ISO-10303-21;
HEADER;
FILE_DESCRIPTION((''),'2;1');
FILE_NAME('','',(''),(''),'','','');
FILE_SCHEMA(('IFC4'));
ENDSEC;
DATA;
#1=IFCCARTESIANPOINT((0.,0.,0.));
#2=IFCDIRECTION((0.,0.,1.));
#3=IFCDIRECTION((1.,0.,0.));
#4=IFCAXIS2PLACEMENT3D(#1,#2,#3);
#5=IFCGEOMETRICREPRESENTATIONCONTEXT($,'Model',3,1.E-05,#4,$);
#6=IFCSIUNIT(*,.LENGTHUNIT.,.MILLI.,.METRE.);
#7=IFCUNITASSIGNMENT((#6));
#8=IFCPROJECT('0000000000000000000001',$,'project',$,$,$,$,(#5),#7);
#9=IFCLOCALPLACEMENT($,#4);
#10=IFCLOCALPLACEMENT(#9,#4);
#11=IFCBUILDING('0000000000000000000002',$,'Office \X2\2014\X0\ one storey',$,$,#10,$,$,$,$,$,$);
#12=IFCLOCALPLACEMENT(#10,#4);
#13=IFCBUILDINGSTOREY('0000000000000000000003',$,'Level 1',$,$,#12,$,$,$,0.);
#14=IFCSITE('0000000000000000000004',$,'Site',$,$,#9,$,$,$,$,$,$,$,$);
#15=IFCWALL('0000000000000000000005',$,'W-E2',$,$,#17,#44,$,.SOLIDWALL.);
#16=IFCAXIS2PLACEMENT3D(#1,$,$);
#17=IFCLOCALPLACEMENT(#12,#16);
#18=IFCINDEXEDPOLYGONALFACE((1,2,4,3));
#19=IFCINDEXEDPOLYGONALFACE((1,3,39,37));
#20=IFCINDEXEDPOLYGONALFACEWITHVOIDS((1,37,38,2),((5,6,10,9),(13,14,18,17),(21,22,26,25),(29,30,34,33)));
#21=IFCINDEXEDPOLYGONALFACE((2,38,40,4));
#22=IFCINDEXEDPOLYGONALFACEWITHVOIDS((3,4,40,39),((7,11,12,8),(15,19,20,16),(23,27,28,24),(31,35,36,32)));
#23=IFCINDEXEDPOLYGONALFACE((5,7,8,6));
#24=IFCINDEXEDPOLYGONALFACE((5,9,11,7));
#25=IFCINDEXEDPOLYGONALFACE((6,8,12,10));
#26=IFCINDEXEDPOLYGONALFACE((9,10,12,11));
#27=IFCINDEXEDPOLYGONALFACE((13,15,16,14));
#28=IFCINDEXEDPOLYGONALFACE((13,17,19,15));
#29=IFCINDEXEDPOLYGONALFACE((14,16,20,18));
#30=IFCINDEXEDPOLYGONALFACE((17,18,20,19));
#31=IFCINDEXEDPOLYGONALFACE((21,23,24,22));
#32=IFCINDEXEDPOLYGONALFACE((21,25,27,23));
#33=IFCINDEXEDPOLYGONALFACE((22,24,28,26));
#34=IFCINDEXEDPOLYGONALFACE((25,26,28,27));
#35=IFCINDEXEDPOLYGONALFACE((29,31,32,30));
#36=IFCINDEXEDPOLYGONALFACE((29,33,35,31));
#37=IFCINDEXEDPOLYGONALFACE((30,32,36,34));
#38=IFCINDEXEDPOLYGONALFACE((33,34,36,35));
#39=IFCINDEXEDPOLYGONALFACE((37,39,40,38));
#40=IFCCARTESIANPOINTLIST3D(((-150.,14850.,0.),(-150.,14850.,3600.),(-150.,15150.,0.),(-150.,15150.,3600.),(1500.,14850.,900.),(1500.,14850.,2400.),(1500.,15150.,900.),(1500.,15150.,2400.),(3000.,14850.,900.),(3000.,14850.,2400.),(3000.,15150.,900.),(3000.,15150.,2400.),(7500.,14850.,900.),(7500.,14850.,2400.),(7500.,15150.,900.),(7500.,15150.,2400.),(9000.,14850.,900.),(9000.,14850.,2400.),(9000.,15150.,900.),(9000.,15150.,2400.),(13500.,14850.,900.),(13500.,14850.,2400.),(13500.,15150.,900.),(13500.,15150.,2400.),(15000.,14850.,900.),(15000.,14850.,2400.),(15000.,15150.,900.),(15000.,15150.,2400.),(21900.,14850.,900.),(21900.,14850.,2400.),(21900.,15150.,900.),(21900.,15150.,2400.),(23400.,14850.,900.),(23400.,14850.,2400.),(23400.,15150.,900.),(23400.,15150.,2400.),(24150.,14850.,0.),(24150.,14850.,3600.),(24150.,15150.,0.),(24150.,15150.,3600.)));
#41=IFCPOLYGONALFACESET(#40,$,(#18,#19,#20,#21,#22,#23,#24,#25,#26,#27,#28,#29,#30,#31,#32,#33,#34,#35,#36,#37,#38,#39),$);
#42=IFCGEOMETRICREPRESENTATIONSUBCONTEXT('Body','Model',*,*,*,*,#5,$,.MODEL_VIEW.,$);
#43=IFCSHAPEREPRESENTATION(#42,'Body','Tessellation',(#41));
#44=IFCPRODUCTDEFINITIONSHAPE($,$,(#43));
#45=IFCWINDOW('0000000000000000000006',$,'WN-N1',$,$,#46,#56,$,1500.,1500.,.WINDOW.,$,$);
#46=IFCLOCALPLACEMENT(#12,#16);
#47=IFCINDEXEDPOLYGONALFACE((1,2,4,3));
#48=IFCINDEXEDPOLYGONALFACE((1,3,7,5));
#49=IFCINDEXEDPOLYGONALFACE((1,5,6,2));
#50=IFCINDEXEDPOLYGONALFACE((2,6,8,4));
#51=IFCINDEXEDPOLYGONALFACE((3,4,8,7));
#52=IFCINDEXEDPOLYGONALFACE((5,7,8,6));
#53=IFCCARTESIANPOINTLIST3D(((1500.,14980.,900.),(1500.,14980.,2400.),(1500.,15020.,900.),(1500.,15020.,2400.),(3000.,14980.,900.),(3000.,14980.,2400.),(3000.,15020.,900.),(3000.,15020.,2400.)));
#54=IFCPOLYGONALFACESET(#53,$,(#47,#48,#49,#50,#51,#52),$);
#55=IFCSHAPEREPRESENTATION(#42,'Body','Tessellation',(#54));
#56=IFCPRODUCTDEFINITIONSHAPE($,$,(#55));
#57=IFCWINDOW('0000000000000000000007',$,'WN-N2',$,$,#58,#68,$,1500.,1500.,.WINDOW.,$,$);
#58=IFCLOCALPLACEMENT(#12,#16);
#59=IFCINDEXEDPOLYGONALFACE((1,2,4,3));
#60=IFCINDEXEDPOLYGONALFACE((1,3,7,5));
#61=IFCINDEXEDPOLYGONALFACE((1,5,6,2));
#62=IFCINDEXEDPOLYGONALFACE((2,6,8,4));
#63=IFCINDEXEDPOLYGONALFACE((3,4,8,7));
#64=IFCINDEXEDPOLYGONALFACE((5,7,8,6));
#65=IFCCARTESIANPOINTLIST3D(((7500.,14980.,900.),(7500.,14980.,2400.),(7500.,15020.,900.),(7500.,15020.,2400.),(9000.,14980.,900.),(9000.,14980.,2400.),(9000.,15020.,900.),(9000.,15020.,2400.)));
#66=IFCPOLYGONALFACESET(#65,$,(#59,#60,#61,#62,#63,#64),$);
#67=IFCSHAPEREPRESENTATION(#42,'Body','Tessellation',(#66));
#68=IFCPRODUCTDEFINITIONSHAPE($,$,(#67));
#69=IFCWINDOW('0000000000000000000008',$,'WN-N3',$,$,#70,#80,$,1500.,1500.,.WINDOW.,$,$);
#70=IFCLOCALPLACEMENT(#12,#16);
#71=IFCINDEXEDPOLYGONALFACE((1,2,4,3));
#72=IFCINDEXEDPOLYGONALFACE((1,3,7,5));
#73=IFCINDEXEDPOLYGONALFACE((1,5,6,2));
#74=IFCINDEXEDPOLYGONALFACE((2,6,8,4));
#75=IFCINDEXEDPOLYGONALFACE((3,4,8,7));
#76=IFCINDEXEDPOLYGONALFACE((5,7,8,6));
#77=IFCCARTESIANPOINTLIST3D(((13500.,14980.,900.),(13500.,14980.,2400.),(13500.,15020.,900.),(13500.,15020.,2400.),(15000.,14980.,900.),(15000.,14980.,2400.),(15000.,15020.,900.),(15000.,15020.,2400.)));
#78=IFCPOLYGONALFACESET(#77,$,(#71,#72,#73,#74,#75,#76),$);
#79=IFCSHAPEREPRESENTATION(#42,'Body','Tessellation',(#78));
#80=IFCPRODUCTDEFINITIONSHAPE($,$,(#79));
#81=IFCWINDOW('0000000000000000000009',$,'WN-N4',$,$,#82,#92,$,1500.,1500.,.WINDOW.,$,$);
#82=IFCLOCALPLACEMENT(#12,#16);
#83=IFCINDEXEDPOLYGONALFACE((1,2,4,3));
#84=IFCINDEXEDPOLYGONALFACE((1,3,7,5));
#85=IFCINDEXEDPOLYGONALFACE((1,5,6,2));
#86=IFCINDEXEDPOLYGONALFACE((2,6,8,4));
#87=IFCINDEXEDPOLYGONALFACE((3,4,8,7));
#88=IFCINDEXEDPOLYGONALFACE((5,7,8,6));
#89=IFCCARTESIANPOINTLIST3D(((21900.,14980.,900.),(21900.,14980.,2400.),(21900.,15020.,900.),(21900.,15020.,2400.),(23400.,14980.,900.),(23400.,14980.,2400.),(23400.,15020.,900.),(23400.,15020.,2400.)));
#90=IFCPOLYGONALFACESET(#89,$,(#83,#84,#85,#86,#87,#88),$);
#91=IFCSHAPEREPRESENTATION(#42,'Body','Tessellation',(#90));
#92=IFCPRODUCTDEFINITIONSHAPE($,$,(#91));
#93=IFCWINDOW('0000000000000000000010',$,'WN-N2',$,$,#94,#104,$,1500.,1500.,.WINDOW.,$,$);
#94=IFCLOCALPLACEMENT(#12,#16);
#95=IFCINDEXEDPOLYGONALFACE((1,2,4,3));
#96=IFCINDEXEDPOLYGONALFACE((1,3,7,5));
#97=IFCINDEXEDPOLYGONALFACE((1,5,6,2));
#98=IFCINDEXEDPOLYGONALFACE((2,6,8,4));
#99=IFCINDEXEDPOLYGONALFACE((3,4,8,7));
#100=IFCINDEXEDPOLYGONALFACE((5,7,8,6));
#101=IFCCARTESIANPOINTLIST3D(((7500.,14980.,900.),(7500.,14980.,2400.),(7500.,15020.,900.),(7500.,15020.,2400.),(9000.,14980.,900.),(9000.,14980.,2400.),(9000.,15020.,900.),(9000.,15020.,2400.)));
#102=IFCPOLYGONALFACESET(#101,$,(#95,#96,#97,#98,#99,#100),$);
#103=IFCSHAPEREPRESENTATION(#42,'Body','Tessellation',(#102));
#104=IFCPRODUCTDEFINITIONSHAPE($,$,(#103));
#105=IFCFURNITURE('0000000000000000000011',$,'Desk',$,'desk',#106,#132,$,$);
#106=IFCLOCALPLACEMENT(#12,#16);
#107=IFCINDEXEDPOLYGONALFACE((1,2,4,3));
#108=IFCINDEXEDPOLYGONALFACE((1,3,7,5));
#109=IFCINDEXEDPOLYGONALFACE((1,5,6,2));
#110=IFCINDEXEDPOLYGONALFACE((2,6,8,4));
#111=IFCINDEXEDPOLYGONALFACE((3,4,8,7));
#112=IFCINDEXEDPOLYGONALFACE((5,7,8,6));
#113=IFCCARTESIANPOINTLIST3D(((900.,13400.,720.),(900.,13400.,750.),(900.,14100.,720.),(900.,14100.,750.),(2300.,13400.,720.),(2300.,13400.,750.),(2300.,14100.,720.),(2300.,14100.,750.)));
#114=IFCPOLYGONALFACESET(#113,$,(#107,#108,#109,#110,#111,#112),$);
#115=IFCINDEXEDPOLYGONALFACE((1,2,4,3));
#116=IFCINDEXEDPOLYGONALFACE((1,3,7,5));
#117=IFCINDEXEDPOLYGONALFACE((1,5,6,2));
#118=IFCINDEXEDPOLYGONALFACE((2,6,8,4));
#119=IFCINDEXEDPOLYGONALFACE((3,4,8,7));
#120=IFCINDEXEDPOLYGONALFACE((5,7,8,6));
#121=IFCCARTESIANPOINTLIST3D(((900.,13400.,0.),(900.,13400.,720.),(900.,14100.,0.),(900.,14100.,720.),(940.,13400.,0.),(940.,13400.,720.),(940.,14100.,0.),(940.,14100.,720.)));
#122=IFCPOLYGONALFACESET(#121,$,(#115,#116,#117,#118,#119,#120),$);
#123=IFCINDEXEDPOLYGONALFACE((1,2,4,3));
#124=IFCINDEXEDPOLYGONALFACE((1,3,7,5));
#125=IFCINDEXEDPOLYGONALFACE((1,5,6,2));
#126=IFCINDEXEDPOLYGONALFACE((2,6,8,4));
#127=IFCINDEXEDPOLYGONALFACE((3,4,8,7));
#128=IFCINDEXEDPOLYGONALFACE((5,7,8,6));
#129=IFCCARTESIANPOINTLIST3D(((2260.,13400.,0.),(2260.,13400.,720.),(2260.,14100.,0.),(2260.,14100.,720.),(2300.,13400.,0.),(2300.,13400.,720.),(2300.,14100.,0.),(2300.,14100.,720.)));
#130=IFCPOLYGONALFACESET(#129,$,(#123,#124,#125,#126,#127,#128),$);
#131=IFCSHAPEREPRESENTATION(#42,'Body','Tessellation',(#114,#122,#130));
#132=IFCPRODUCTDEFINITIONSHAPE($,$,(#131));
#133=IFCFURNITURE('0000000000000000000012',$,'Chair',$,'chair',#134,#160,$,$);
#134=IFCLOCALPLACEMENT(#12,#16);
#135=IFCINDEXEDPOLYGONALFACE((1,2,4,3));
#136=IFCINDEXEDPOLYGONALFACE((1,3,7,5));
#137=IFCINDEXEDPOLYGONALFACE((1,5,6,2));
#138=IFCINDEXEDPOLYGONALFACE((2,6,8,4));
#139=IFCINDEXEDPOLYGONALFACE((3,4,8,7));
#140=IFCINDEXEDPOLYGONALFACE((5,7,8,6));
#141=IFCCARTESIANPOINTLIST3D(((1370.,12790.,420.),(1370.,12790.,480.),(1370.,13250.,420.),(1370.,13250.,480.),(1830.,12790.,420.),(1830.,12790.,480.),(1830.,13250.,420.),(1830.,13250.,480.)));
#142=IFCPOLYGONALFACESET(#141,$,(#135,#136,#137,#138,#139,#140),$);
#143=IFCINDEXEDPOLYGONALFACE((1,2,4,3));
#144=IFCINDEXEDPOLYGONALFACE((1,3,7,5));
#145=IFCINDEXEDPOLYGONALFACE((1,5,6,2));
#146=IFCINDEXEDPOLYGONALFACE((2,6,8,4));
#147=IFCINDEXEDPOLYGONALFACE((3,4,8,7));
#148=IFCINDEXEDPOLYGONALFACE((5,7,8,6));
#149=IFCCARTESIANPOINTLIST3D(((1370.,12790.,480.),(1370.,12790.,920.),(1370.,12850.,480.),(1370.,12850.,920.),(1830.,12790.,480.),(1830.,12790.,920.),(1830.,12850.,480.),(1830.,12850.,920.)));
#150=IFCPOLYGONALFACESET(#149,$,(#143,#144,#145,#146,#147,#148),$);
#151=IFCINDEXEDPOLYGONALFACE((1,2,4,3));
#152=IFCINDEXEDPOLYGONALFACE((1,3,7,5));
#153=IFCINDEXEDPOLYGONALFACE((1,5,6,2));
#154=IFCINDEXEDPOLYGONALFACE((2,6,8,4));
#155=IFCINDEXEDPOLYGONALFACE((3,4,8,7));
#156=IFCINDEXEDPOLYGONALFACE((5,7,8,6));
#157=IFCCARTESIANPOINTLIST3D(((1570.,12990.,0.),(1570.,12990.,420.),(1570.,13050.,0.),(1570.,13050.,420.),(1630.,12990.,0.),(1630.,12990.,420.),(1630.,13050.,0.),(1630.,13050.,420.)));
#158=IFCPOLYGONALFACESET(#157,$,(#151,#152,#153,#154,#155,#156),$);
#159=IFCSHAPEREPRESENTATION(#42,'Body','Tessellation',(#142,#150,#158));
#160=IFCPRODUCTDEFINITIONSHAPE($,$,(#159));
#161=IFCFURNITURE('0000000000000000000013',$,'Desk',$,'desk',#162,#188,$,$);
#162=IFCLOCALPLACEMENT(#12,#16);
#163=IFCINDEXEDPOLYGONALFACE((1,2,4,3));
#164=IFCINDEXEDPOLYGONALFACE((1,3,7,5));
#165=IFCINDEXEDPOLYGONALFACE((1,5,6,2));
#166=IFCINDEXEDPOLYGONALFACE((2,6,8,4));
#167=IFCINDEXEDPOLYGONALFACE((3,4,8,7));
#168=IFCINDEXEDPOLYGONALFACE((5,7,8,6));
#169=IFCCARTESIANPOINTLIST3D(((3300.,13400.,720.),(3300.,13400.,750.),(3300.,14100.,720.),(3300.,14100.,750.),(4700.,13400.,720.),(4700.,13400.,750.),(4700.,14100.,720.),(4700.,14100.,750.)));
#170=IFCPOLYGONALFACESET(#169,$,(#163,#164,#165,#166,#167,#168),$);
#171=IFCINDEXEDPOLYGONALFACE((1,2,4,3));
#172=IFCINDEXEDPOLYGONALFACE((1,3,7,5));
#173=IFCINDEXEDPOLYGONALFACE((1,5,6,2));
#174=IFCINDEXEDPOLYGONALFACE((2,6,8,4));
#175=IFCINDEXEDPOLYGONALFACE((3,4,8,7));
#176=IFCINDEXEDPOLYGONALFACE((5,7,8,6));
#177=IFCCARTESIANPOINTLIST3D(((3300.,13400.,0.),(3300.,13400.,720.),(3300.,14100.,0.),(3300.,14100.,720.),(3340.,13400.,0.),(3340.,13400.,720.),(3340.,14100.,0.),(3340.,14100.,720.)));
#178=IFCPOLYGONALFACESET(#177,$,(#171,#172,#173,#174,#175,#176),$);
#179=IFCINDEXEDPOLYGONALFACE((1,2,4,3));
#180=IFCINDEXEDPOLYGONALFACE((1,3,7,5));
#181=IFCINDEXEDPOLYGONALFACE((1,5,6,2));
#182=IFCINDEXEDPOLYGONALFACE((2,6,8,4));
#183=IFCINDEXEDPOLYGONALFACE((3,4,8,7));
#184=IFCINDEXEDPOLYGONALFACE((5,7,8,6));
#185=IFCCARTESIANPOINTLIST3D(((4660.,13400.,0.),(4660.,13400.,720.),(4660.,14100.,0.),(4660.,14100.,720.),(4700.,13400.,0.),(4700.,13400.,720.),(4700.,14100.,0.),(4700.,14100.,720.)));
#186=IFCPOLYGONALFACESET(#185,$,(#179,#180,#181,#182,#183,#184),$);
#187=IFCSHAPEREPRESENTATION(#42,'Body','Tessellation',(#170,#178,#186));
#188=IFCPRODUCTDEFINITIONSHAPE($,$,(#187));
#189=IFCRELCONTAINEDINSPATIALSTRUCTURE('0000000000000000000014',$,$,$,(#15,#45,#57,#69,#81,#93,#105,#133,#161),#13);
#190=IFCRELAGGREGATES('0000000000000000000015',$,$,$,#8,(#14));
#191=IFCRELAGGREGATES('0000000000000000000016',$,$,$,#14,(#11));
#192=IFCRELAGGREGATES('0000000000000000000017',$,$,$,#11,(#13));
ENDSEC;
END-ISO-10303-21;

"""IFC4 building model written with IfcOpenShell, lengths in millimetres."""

from ifc_helpers import new_model, si_unit, frame, frame_2d, origin, origin_with_axes, place, context, subcontext, project, spatial, rectangle, extrude, element, fill, save


model = new_model("IFC4")

# Units and contexts
model_context = context("Model", 3, precision=1e-05, world=origin_with_axes())
body_context = subcontext(model_context, "Body", "Model", "MODEL_VIEW")
ifc_project = project(units=[si_unit("LENGTHUNIT", "METRE", prefix="MILLI")], contexts=[model_context])

# Site, building, storey
site_placement = place(None, origin_with_axes())
site = spatial("IfcSite", under=ifc_project, at=site_placement, Name="Site")
building_placement = place(site_placement, origin_with_axes())
building = spatial("IfcBuilding", under=site, at=building_placement, Name="Office — one storey")
storey_placement = place(building_placement, origin_with_axes())
storey = spatial("IfcBuildingStorey", under=building, at=storey_placement, Name="Level 1", Elevation=0.0)

# Wall, openings, windows
wall_placement = place(storey_placement, frame((0.0, 14850.0, 0.0), z_axis=(0.0, 0.0, 1.0), x_axis=(1.0, 0.0, 0.0)))
wall = element("IfcWall", 1, at=wall_placement, inside=storey, Name="W-E2", PredefinedType="SOLIDWALL", context=body_context, shape_type="SweptSolid", body=[
    extrude(rectangle(XDim=24300.0, YDim=300.0, at=frame_2d((12000.0, 150.0))), origin(), (0.0, 0.0, 1.0), 3600.0),
])
opening_1_placement = place(wall_placement, frame((1500.0, -10.0, 900.0), z_axis=(0.0, 0.0, 1.0), x_axis=(1.0, 0.0, 0.0)))
opening_1 = element("IfcOpeningElement", 2, at=opening_1_placement, cuts=wall, context=body_context, shape_type="SweptSolid", body=[
    extrude(rectangle(XDim=1500.0, YDim=320.0, at=frame_2d((750.0, 160.0))), origin(), (0.0, 0.0, 1.0), 1500.0),
])
opening_2_placement = place(wall_placement, frame((7500.0, -10.0, 900.0), z_axis=(0.0, 0.0, 1.0), x_axis=(1.0, 0.0, 0.0)))
opening_2 = element("IfcOpeningElement", 3, at=opening_2_placement, cuts=wall, context=body_context, shape_type="SweptSolid", body=[
    extrude(rectangle(XDim=1500.0, YDim=320.0, at=frame_2d((750.0, 160.0))), origin(), (0.0, 0.0, 1.0), 1500.0),
])
opening_3_placement = place(wall_placement, frame((13500.0, -10.0, 900.0), z_axis=(0.0, 0.0, 1.0), x_axis=(1.0, 0.0, 0.0)))
opening_3 = element("IfcOpeningElement", 4, at=opening_3_placement, cuts=wall, context=body_context, shape_type="SweptSolid", body=[
    extrude(rectangle(XDim=1500.0, YDim=320.0, at=frame_2d((750.0, 160.0))), origin(), (0.0, 0.0, 1.0), 1500.0),
])
opening_4_placement = place(wall_placement, frame((21900.0, -10.0, 900.0), z_axis=(0.0, 0.0, 1.0), x_axis=(1.0, 0.0, 0.0)))
opening_4 = element("IfcOpeningElement", 5, at=opening_4_placement, cuts=wall, context=body_context, shape_type="SweptSolid", body=[
    extrude(rectangle(XDim=1500.0, YDim=320.0, at=frame_2d((750.0, 160.0))), origin(), (0.0, 0.0, 1.0), 1500.0),
])
opening_5_placement = place(wall_placement, frame((7500.0, -10.0, 900.0), z_axis=(0.0, 0.0, 1.0), x_axis=(1.0, 0.0, 0.0)))
opening_5 = element("IfcOpeningElement", 6, at=opening_5_placement, cuts=wall, context=body_context, shape_type="SweptSolid", body=[
    extrude(rectangle(XDim=1500.0, YDim=320.0, at=frame_2d((750.0, 160.0))), origin(), (0.0, 0.0, 1.0), 1500.0),
])
window_1_placement = place(storey_placement, frame((1500.0, 14980.0, 900.0), z_axis=(0.0, 0.0, 1.0), x_axis=(1.0, 0.0, 0.0)))
window_1 = element("IfcWindow", 7, at=window_1_placement, inside=storey, Name="WN-N1", OverallHeight=1500.0, OverallWidth=1500.0, PredefinedType="WINDOW", context=body_context, shape_type="SweptSolid", body=[
    extrude(rectangle(XDim=1500.0, YDim=40.0, at=frame_2d((750.0, 20.0))), origin(), (0.0, 0.0, 1.0), 1500.0),
])
fill(opening_1, window_1)
window_2_placement = place(storey_placement, frame((7500.0, 14980.0, 900.0), z_axis=(0.0, 0.0, 1.0), x_axis=(1.0, 0.0, 0.0)))
window_2 = element("IfcWindow", 8, at=window_2_placement, inside=storey, Name="WN-N2", OverallHeight=1500.0, OverallWidth=1500.0, PredefinedType="WINDOW", context=body_context, shape_type="SweptSolid", body=[
    extrude(rectangle(XDim=1500.0, YDim=40.0, at=frame_2d((750.0, 20.0))), origin(), (0.0, 0.0, 1.0), 1500.0),
])
fill(opening_2, window_2)
window_3_placement = place(storey_placement, frame((13500.0, 14980.0, 900.0), z_axis=(0.0, 0.0, 1.0), x_axis=(1.0, 0.0, 0.0)))
window_3 = element("IfcWindow", 9, at=window_3_placement, inside=storey, Name="WN-N3", OverallHeight=1500.0, OverallWidth=1500.0, PredefinedType="WINDOW", context=body_context, shape_type="SweptSolid", body=[
    extrude(rectangle(XDim=1500.0, YDim=40.0, at=frame_2d((750.0, 20.0))), origin(), (0.0, 0.0, 1.0), 1500.0),
])
fill(opening_3, window_3)
window_4_placement = place(storey_placement, frame((21900.0, 14980.0, 900.0), z_axis=(0.0, 0.0, 1.0), x_axis=(1.0, 0.0, 0.0)))
window_4 = element("IfcWindow", 10, at=window_4_placement, inside=storey, Name="WN-N4", OverallHeight=1500.0, OverallWidth=1500.0, PredefinedType="WINDOW", context=body_context, shape_type="SweptSolid", body=[
    extrude(rectangle(XDim=1500.0, YDim=40.0, at=frame_2d((750.0, 20.0))), origin(), (0.0, 0.0, 1.0), 1500.0),
])
fill(opening_4, window_4)
window_5_placement = place(storey_placement, frame((7500.0, 14980.0, 900.0), z_axis=(0.0, 0.0, 1.0), x_axis=(1.0, 0.0, 0.0)))
window_5 = element("IfcWindow", 11, at=window_5_placement, inside=storey, Name="WN-N2", OverallHeight=1500.0, OverallWidth=1500.0, PredefinedType="WINDOW", context=body_context, shape_type="SweptSolid", body=[
    extrude(rectangle(XDim=1500.0, YDim=40.0, at=frame_2d((750.0, 20.0))), origin(), (0.0, 0.0, 1.0), 1500.0),
])
fill(opening_5, window_5)

# Furniture
furniture_1_placement = place(storey_placement, frame((900.0, 13400.0, 0.0), z_axis=(0.0, 0.0, 1.0), x_axis=(1.0, 0.0, 0.0)))
element("IfcFurniture", 12, at=furniture_1_placement, inside=storey, Name="Desk", ObjectType="desk", context=body_context, shape_type="SweptSolid", body=[
    extrude(rectangle(XDim=1400.0, YDim=700.0, at=frame_2d((700.0, 350.0))), frame((0.0, 0.0, 720.0)), (0.0, 0.0, 1.0), 30.0),
    extrude(rectangle(XDim=40.0, YDim=700.0, at=frame_2d((20.0, 350.0))), origin(), (0.0, 0.0, 1.0), 720.0),
    extrude(rectangle(XDim=40.0, YDim=700.0, at=frame_2d((1380.0, 350.0))), origin(), (0.0, 0.0, 1.0), 720.0),
])
furniture_2_placement = place(storey_placement, frame((1370.0, 12790.0, 0.0), z_axis=(0.0, 0.0, 1.0), x_axis=(1.0, 0.0, 0.0)))
element("IfcFurniture", 13, at=furniture_2_placement, inside=storey, Name="Chair", ObjectType="chair", context=body_context, shape_type="SweptSolid", body=[
    extrude(rectangle(XDim=460.0, YDim=460.0, at=frame_2d((230.0, 230.0))), frame((0.0, 0.0, 420.0)), (0.0, 0.0, 1.0), 60.0),
    extrude(rectangle(XDim=460.0, YDim=60.0, at=frame_2d((230.0, 30.0))), frame((0.0, 0.0, 480.0)), (0.0, 0.0, 1.0), 440.0),
    extrude(rectangle(XDim=60.0, YDim=60.0, at=frame_2d((230.0, 230.0))), origin(), (0.0, 0.0, 1.0), 420.0),
])
furniture_3_placement = place(storey_placement, frame((3300.0, 13400.0, 0.0), z_axis=(0.0, 0.0, 1.0), x_axis=(1.0, 0.0, 0.0)))
element("IfcFurniture", 14, at=furniture_3_placement, inside=storey, Name="Desk", ObjectType="desk", context=body_context, shape_type="SweptSolid", body=[
    extrude(rectangle(XDim=1400.0, YDim=700.0, at=frame_2d((700.0, 350.0))), frame((0.0, 0.0, 720.0)), (0.0, 0.0, 1.0), 30.0),
    extrude(rectangle(XDim=40.0, YDim=700.0, at=frame_2d((20.0, 350.0))), origin(), (0.0, 0.0, 1.0), 720.0),
    extrude(rectangle(XDim=40.0, YDim=700.0, at=frame_2d((1380.0, 350.0))), origin(), (0.0, 0.0, 1.0), 720.0),
])

save(model, "model.ifc")
